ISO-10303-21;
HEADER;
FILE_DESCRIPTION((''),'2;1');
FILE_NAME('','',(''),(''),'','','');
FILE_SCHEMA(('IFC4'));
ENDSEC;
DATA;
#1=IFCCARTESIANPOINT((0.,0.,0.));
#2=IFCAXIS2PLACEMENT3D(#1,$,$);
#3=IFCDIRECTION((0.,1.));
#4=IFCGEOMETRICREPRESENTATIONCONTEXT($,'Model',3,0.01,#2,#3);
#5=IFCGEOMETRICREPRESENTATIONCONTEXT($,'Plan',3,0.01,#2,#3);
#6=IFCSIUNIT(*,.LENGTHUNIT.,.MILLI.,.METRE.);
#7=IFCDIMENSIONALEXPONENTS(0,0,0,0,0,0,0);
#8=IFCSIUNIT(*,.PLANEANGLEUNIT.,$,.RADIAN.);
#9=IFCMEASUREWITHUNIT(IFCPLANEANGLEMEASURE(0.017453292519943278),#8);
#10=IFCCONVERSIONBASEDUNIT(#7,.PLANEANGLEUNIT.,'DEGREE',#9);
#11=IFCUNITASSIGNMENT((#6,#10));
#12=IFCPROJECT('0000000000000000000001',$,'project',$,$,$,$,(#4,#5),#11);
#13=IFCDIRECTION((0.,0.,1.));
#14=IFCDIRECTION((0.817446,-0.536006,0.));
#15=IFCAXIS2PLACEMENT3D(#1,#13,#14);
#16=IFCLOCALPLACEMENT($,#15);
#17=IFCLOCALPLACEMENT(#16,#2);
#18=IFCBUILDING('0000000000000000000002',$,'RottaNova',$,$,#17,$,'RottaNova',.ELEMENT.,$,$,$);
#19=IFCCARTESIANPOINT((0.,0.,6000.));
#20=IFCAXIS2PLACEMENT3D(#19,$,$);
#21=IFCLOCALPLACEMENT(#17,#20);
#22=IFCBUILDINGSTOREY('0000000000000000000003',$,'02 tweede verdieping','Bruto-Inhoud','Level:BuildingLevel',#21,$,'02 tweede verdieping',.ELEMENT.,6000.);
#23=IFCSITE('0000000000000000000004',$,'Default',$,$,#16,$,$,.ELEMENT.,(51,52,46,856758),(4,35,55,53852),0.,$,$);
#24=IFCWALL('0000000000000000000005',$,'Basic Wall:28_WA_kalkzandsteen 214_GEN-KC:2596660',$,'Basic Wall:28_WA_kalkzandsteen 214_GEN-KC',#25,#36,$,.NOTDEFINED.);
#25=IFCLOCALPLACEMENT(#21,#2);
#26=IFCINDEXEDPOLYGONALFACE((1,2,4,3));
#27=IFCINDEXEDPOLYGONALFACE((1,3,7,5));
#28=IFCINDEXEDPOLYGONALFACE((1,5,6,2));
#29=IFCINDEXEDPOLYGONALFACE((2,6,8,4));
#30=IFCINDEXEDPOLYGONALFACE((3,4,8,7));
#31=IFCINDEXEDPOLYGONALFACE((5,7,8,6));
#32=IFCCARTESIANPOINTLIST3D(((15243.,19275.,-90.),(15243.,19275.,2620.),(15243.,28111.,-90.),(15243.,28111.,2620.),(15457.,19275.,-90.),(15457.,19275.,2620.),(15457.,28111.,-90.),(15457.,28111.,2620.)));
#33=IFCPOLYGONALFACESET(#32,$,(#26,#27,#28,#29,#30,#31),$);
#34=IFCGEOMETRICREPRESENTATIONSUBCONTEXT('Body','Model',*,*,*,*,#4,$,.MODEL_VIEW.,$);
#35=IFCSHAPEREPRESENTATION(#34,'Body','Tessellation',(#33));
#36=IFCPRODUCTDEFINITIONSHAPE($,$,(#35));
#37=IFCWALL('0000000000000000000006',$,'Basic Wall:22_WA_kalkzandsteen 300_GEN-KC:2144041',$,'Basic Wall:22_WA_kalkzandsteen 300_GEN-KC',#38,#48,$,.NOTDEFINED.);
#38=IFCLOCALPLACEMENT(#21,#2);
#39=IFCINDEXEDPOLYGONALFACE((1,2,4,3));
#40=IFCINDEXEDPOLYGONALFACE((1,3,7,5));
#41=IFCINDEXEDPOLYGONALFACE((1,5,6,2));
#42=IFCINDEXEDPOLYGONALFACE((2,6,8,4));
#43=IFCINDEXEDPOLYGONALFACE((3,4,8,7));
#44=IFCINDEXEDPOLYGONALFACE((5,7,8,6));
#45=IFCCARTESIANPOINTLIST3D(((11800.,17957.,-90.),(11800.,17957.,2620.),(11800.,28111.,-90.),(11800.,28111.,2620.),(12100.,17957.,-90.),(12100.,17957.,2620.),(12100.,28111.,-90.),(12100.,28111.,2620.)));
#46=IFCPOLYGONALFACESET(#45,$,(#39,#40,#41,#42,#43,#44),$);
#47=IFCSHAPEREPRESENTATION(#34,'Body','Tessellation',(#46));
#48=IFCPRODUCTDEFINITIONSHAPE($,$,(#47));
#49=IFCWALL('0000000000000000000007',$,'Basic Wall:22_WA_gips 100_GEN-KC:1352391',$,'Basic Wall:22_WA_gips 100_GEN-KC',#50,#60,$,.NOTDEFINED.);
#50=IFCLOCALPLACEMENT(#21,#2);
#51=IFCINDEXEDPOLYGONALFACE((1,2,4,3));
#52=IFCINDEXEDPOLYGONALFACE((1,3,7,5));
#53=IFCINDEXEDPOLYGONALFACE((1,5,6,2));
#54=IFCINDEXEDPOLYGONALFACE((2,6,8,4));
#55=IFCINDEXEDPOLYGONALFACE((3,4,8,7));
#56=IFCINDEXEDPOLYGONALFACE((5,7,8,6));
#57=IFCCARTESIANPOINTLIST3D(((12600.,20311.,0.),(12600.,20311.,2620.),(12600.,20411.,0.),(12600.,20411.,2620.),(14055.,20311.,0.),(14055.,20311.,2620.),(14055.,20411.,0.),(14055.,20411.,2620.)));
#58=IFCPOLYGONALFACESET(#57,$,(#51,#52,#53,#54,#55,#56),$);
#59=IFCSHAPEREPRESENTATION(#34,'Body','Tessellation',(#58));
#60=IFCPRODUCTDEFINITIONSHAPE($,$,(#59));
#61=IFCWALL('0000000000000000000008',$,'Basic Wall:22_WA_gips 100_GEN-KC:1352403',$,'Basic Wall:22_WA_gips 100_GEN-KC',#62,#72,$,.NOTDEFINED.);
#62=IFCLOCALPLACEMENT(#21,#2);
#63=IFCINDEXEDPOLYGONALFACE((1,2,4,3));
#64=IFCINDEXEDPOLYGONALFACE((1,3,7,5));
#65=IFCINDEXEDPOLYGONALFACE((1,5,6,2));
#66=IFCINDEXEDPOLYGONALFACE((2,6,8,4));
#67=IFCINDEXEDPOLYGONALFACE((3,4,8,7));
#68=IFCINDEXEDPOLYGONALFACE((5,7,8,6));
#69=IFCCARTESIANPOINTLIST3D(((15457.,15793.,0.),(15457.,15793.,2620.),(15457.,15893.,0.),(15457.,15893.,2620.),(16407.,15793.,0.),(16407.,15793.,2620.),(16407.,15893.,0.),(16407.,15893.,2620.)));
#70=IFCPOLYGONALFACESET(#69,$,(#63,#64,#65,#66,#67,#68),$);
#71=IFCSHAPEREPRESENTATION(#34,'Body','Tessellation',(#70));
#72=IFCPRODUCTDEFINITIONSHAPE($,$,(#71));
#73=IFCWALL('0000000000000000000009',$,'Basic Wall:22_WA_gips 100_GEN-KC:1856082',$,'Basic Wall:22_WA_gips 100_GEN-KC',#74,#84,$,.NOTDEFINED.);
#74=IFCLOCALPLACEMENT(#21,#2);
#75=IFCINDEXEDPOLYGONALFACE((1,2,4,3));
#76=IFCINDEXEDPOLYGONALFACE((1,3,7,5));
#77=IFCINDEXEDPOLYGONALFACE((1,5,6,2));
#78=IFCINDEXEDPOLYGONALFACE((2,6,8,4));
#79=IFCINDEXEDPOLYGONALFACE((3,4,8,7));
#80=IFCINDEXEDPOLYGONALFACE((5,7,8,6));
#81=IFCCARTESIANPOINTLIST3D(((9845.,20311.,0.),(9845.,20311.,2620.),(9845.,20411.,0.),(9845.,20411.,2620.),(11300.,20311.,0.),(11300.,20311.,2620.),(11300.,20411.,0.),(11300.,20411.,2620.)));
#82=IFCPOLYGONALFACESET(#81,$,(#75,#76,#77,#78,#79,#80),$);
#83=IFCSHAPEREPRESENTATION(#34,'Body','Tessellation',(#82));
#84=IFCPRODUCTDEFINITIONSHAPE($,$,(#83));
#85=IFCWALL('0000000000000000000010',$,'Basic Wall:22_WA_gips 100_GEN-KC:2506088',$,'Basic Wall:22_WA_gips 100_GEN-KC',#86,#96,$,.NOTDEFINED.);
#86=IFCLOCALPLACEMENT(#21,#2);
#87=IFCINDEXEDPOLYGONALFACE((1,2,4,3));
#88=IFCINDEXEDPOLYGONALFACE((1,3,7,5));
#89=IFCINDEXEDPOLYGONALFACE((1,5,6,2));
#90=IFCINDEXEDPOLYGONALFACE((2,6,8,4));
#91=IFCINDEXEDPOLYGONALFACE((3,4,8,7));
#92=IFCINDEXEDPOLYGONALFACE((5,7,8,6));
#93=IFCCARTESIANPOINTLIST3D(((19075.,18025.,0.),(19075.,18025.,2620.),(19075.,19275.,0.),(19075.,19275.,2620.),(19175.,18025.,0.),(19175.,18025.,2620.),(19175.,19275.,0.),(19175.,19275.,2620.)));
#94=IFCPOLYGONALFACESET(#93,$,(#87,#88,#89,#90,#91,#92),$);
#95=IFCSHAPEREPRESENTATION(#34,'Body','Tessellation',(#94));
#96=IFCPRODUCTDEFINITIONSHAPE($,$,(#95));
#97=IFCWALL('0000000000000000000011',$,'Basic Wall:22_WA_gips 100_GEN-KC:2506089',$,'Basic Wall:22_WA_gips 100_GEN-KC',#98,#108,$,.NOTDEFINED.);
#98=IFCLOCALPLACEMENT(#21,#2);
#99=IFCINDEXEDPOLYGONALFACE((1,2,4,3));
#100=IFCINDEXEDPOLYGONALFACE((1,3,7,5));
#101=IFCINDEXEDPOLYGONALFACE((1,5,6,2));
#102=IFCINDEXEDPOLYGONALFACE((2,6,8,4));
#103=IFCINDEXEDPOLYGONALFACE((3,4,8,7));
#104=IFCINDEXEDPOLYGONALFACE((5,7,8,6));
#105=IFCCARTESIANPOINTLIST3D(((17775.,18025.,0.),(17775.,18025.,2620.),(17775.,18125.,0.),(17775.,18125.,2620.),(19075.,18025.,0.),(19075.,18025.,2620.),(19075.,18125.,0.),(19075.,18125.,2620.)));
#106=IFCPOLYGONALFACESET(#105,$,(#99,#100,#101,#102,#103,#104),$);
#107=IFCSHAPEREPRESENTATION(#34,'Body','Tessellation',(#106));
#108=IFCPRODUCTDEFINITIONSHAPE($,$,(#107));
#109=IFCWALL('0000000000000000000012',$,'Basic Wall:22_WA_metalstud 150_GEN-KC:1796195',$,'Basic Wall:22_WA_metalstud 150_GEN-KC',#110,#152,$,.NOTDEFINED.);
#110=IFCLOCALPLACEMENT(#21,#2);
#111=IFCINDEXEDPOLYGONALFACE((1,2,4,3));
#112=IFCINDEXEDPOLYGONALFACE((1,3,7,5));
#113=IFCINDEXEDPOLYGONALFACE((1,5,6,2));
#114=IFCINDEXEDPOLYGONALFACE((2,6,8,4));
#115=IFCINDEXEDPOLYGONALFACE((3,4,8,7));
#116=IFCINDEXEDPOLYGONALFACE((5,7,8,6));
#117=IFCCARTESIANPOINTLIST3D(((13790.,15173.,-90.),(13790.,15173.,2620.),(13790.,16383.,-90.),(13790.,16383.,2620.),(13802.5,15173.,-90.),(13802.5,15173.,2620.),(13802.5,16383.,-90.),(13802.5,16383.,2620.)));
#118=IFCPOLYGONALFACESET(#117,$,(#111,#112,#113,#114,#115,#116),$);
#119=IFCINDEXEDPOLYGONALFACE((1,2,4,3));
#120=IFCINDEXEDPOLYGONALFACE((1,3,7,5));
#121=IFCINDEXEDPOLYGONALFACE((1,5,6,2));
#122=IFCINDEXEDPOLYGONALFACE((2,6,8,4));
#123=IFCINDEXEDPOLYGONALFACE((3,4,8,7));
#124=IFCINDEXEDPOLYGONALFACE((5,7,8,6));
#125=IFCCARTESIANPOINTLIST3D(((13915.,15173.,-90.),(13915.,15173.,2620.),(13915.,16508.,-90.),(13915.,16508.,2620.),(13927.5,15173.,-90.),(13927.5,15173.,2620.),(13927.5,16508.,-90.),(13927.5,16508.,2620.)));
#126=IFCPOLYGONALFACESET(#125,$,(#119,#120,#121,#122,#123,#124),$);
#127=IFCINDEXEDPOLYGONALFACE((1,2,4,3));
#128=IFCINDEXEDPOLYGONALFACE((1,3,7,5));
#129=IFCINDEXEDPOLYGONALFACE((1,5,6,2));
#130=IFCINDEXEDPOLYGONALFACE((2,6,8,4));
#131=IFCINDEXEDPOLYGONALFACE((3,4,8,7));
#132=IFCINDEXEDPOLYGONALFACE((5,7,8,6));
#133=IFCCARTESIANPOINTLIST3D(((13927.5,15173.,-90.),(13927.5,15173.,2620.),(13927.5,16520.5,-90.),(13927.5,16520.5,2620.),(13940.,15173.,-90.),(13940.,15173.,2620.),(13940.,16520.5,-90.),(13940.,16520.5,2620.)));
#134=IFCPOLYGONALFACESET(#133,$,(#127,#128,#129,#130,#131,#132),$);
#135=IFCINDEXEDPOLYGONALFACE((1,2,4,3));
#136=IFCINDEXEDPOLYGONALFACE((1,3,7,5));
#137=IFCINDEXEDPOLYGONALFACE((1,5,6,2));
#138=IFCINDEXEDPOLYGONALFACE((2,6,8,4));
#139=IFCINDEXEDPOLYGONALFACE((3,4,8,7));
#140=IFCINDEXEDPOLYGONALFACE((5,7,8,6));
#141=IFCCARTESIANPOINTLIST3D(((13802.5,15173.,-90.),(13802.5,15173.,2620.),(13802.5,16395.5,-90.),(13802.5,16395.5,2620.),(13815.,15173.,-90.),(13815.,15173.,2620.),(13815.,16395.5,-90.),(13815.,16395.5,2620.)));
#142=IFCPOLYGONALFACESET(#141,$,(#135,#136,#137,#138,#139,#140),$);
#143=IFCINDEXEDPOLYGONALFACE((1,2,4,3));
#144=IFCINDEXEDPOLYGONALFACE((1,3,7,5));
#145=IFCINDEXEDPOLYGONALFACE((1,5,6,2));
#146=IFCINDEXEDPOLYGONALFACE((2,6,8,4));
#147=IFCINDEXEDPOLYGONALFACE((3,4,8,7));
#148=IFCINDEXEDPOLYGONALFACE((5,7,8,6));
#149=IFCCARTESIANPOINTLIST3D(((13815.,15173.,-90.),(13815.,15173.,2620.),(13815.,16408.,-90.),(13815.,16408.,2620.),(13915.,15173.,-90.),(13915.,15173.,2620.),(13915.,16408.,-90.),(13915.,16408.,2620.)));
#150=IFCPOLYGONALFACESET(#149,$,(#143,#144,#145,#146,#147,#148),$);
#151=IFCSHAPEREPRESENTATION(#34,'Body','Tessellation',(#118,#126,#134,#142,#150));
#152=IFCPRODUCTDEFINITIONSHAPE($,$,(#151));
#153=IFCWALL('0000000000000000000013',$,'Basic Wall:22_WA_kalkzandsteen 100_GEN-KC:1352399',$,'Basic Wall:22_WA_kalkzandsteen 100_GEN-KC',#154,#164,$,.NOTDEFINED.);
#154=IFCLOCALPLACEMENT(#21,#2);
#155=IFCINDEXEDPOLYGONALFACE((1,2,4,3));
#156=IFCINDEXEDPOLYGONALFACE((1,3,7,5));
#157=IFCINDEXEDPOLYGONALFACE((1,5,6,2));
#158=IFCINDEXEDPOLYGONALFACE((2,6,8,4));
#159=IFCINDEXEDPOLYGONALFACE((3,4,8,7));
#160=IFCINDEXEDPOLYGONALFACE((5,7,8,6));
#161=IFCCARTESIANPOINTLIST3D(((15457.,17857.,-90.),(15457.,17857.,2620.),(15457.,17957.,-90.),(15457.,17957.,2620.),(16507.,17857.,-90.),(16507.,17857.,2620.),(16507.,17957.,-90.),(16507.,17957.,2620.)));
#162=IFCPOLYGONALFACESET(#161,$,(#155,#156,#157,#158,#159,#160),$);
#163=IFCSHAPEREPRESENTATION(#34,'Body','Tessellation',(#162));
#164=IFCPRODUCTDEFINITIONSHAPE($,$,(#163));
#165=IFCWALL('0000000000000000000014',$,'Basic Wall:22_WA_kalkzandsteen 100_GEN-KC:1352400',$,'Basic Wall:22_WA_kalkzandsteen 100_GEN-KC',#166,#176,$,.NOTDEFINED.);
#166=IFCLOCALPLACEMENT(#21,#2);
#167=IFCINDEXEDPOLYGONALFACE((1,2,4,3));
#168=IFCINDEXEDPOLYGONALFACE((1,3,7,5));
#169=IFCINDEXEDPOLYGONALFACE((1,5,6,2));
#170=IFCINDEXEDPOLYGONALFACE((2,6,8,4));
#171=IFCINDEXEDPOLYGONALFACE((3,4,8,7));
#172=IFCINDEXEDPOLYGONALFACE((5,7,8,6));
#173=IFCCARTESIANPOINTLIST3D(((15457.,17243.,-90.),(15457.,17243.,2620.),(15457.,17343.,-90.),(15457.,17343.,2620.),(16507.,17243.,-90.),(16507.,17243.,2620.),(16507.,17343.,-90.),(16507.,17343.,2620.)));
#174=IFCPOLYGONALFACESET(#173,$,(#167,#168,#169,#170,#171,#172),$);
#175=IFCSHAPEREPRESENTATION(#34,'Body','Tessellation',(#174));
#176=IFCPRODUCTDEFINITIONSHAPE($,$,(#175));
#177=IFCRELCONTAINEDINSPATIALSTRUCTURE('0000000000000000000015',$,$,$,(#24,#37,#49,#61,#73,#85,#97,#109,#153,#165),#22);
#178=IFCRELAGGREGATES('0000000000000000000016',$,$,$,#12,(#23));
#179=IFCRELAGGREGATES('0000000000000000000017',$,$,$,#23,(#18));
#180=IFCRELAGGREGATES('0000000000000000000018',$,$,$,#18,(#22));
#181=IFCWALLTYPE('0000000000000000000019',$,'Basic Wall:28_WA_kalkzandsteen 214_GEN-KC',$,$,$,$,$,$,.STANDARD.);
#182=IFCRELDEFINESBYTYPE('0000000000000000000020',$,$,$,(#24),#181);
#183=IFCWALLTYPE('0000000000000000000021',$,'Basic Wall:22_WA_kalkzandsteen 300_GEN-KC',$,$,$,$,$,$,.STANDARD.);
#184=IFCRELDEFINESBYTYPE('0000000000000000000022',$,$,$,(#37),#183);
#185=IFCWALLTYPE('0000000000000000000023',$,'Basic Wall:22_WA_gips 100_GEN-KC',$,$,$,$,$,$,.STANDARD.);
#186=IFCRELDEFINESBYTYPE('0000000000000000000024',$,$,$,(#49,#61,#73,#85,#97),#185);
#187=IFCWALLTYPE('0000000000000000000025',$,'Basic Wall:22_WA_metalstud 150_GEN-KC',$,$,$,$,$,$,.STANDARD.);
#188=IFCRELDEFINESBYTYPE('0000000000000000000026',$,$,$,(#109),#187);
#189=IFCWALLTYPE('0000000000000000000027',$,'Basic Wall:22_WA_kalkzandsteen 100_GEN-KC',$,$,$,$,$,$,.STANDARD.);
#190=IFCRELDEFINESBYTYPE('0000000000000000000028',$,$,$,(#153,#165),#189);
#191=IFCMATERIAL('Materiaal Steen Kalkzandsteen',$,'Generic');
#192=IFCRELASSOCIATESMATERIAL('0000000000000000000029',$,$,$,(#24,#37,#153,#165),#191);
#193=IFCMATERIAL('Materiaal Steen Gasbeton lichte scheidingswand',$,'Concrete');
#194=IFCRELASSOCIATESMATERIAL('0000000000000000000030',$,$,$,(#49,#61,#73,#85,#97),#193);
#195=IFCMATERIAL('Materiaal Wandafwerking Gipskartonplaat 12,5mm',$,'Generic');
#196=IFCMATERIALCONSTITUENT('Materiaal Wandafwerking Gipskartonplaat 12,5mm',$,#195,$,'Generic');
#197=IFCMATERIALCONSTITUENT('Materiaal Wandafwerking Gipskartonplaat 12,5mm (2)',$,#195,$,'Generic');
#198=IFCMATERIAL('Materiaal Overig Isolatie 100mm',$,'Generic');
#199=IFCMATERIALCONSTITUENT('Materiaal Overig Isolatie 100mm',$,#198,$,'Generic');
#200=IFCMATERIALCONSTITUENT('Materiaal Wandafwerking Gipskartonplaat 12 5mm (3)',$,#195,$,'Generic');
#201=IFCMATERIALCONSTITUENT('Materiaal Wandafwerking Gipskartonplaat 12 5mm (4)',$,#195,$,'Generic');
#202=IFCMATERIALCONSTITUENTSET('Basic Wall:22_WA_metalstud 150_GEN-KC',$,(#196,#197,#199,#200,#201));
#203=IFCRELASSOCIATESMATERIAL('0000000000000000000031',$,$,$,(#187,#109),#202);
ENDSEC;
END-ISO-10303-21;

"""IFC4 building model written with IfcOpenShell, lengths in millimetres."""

from ifc_helpers import new_model, entity, si_unit, converted_unit, direction, frame, origin, place, context, subcontext, project, spatial, indexed_curve, outline, extrude, material, constituent, constituent_set, type_object, element, save


model = new_model("IFC4")

# Units and contexts
model_context = context("Model", 3, precision=0.01, world=origin(), true_north=direction((0.0, 1.0)))
plan_context = context("Plan", 3, precision=0.01, world=origin(), true_north=direction((0.0, 1.0)))
body_context = subcontext(model_context, "Body", "Model", "MODEL_VIEW")
ifc_project = project(units=[si_unit("LENGTHUNIT", "METRE", prefix="MILLI"), converted_unit("PLANEANGLEUNIT", "DEGREE", entity("IfcPlaneAngleMeasure", 0.017453292519943278), si_unit("PLANEANGLEUNIT", "RADIAN"), dimensions=[0, 0, 0, 0, 0, 0, 0])], contexts=[model_context, plan_context])

# Site, building, storey
site_placement = place(None, frame((0.0, 0.0, 0.0), z_axis=(0.0, 0.0, 1.0), x_axis=(0.817446, -0.536006, 0.0)))
site = spatial("IfcSite", under=ifc_project, at=site_placement, Name="Default", CompositionType="ELEMENT", RefLatitude=(51, 52, 46, 856758), RefLongitude=(4, 35, 55, 53852), RefElevation=0.0)
building_placement = place(site_placement, origin())
building = spatial("IfcBuilding", under=site, at=building_placement, Name="RottaNova", LongName="RottaNova", CompositionType="ELEMENT")
storey_placement = place(building_placement, frame((0.0, 0.0, 6000.0)))
storey = spatial("IfcBuildingStorey", under=building, at=storey_placement, Name="02 tweede verdieping", Description="Bruto-Inhoud", ObjectType="Level:BuildingLevel", LongName="02 tweede verdieping", CompositionType="ELEMENT", Elevation=6000.0)

# Walls
ifc_material_1 = material(Name="Materiaal Steen Kalkzandsteen", Category="Generic")
wall_type_1 = type_object("IfcWallType", Name="Basic Wall:28_WA_kalkzandsteen 214_GEN-KC", PredefinedType="STANDARD")
wall_1_placement = place(storey_placement, frame((15350.0, 19275.0, -90.0), z_axis=(0.0, 0.0, 1.0), x_axis=(0.0, 1.0, 0.0)))
element("IfcWall", 1, at=wall_1_placement, inside=storey, type_object=wall_type_1, material=ifc_material_1, Name="Basic Wall:28_WA_kalkzandsteen 214_GEN-KC:2596660", ObjectType="Basic Wall:28_WA_kalkzandsteen 214_GEN-KC", PredefinedType="NOTDEFINED", context=body_context, shape_type="SweptSolid", body=[
    extrude(outline(indexed_curve([(-4418.0, -107.0), (4418.0, -107.0), (4418.0, 107.0), (-4418.0, 107.0), (-4418.0, -107.0)], self_intersect=False)), frame((4418.0, 0.0, 0.0), z_axis=(0.0, 0.0, 1.0), x_axis=(-1.0, 0.0, 0.0)), (0.0, 0.0, 1.0), 2710.0),
])
wall_type_2 = type_object("IfcWallType", Name="Basic Wall:22_WA_kalkzandsteen 300_GEN-KC", PredefinedType="STANDARD")
wall_2_placement = place(storey_placement, frame((11950.0, 17957.0, -90.0), z_axis=(0.0, 0.0, 1.0), x_axis=(0.0, 1.0, 0.0)))
element("IfcWall", 2, at=wall_2_placement, inside=storey, type_object=wall_type_2, material=ifc_material_1, Name="Basic Wall:22_WA_kalkzandsteen 300_GEN-KC:2144041", ObjectType="Basic Wall:22_WA_kalkzandsteen 300_GEN-KC", PredefinedType="NOTDEFINED", context=body_context, shape_type="SweptSolid", body=[
    extrude(outline(indexed_curve([(10154.0, 150.0), (0.0, 150.0), (0.0, -150.0), (10154.0, -150.0), (10154.0, 150.0)], self_intersect=False)), origin(), (0.0, 0.0, 1.0), 2710.0),
])
ifc_material_2 = material(Name="Materiaal Steen Gasbeton lichte scheidingswand", Category="Concrete")
wall_type_3 = type_object("IfcWallType", Name="Basic Wall:22_WA_gips 100_GEN-KC", PredefinedType="STANDARD")
wall_3_placement = place(storey_placement, frame((14055.0, 20361.0, 0.0), z_axis=(0.0, 0.0, 1.0), x_axis=(-1.0, 0.0, 0.0)))
element("IfcWall", 3, at=wall_3_placement, inside=storey, type_object=wall_type_3, material=ifc_material_2, Name="Basic Wall:22_WA_gips 100_GEN-KC:1352391", ObjectType="Basic Wall:22_WA_gips 100_GEN-KC", PredefinedType="NOTDEFINED", context=body_context, shape_type="SweptSolid", body=[
    extrude(outline(indexed_curve([(1455.0, 50.0), (0.0, 50.0), (0.0, -50.0), (1455.0, -50.0), (1455.0, 50.0)], self_intersect=False)), origin(), (0.0, 0.0, 1.0), 2620.0),
])
wall_4_placement = place(storey_placement, frame((16407.0, 15843.0, 0.0), z_axis=(0.0, 0.0, 1.0), x_axis=(-1.0, 0.0, 0.0)))
element("IfcWall", 4, at=wall_4_placement, inside=storey, type_object=wall_type_3, material=ifc_material_2, Name="Basic Wall:22_WA_gips 100_GEN-KC:1352403", ObjectType="Basic Wall:22_WA_gips 100_GEN-KC", PredefinedType="NOTDEFINED", context=body_context, shape_type="SweptSolid", body=[
    extrude(outline(indexed_curve([(950.0, 50.0), (0.0, 50.0), (0.0, -50.0), (950.0, -50.0), (950.0, 50.0)], self_intersect=False)), origin(), (0.0, 0.0, 1.0), 2620.0),
])
wall_5_placement = place(storey_placement, frame((9845.0, 20361.0, 0.0)))
element("IfcWall", 5, at=wall_5_placement, inside=storey, type_object=wall_type_3, material=ifc_material_2, Name="Basic Wall:22_WA_gips 100_GEN-KC:1856082", ObjectType="Basic Wall:22_WA_gips 100_GEN-KC", PredefinedType="NOTDEFINED", context=body_context, shape_type="SweptSolid", body=[
    extrude(outline(indexed_curve([(1455.0, 50.0), (0.0, 50.0), (0.0, -50.0), (1455.0, -50.0), (1455.0, 50.0)], self_intersect=False)), origin(), (0.0, 0.0, 1.0), 2620.0),
])
wall_6_placement = place(storey_placement, frame((19125.0, 19275.0, 0.0), z_axis=(0.0, 0.0, 1.0), x_axis=(0.0, -1.0, 0.0)))
element("IfcWall", 6, at=wall_6_placement, inside=storey, type_object=wall_type_3, material=ifc_material_2, Name="Basic Wall:22_WA_gips 100_GEN-KC:2506088", ObjectType="Basic Wall:22_WA_gips 100_GEN-KC", PredefinedType="NOTDEFINED", context=body_context, shape_type="SweptSolid", body=[
    extrude(outline(indexed_curve([(1250.0, 50.0), (0.0, 50.0), (0.0, -50.0), (1250.0, -50.0), (1250.0, 50.0)], self_intersect=False)), origin(), (0.0, 0.0, 1.0), 2620.0),
])
wall_7_placement = place(storey_placement, frame((19075.0, 18075.0, 0.0), z_axis=(0.0, 0.0, 1.0), x_axis=(-1.0, 0.0, 0.0)))
element("IfcWall", 7, at=wall_7_placement, inside=storey, type_object=wall_type_3, material=ifc_material_2, Name="Basic Wall:22_WA_gips 100_GEN-KC:2506089", ObjectType="Basic Wall:22_WA_gips 100_GEN-KC", PredefinedType="NOTDEFINED", context=body_context, shape_type="SweptSolid", body=[
    extrude(outline(indexed_curve([(1300.0, 50.0), (0.0, 50.0), (0.0, -50.0), (1300.0, -50.0), (1300.0, 50.0)], self_intersect=False)), origin(), (0.0, 0.0, 1.0), 2620.0),
])
ifc_material_3 = material(Name="Materiaal Wandafwerking Gipskartonplaat 12,5mm", Category="Generic")
ifc_constituent_1 = constituent(ifc_material_3, Name="Materiaal Wandafwerking Gipskartonplaat 12,5mm", Category="Generic")
ifc_constituent_2 = constituent(ifc_material_3, Name="Materiaal Wandafwerking Gipskartonplaat 12,5mm (2)", Category="Generic")
ifc_material_4 = material(Name="Materiaal Overig Isolatie 100mm", Category="Generic")
ifc_constituent_3 = constituent(ifc_material_4, Name="Materiaal Overig Isolatie 100mm", Category="Generic")
ifc_constituent_4 = constituent(ifc_material_3, Name="Materiaal Wandafwerking Gipskartonplaat 12 5mm (3)", Category="Generic")
ifc_constituent_5 = constituent(ifc_material_3, Name="Materiaal Wandafwerking Gipskartonplaat 12 5mm (4)", Category="Generic")
ifc_constituent_set_1 = constituent_set(constituents=[ifc_constituent_1, ifc_constituent_2, ifc_constituent_3, ifc_constituent_4, ifc_constituent_5], Name="Basic Wall:22_WA_metalstud 150_GEN-KC")
wall_type_4 = type_object("IfcWallType", Name="Basic Wall:22_WA_metalstud 150_GEN-KC", PredefinedType="STANDARD", material=ifc_constituent_set_1)
wall_8_placement = place(storey_placement, frame((13865.0, 15173.0, -90.0), z_axis=(0.0, 0.0, 1.0), x_axis=(0.0, 1.0, 0.0)))
element("IfcWall", 8, at=wall_8_placement, inside=storey, type_object=wall_type_4, material=ifc_constituent_set_1, Name="Basic Wall:22_WA_metalstud 150_GEN-KC:1796195", ObjectType="Basic Wall:22_WA_metalstud 150_GEN-KC", PredefinedType="NOTDEFINED", context=body_context, shape_type="SweptSolid", body=[
    extrude(outline(indexed_curve([(-6.3, -605.0), (6.2, -605.0), (6.3, 605.0), (-6.2, 605.0), (-6.3, -605.0)], self_intersect=False)), frame((605.0, 68.8, 0.0), z_axis=(0.0, 0.0, 1.0), x_axis=(0.0, -1.0, 0.0)), (0.0, 0.0, 1.0), 2710.0),
    extrude(outline(indexed_curve([(-667.5, -6.3), (667.5, -6.3), (667.5, 6.2), (-667.5, 6.3), (-667.5, -6.3)], self_intersect=False)), frame((667.5, -56.2, 0.0)), (0.0, 0.0, 1.0), 2710.0),
    extrude(outline(indexed_curve([(-6.2, -673.7), (6.3, -673.7), (6.3, 673.7), (-6.2, 673.7), (-6.2, -673.7)], self_intersect=False)), frame((673.7, -68.8, 0.0), z_axis=(0.0, 0.0, 1.0), x_axis=(0.0, 1.0, 0.0)), (0.0, 0.0, 1.0), 2710.0),
    extrude(outline(indexed_curve([(-611.2, -6.3), (611.2, -6.3), (611.2, 6.2), (-611.2, 6.3), (-611.2, -6.3)], self_intersect=False)), frame((611.2, 56.3, 0.0)), (0.0, 0.0, 1.0), 2710.0),
    extrude(outline(indexed_curve([(-617.5, -50.0), (617.5, -50.0), (617.5, 50.0), (-617.5, 50.0), (-617.5, -50.0)], self_intersect=False)), frame((617.5, 0.0, 0.0)), (0.0, 0.0, 1.0), 2710.0),
])
wall_type_5 = type_object("IfcWallType", Name="Basic Wall:22_WA_kalkzandsteen 100_GEN-KC", PredefinedType="STANDARD")
for number, where, z_axis, x_axis, name in (
    (9, (16507.0, 17907.0, -90.0), (0.0, 0.0, 1.0), (-1.0, 0.0, 0.0), "Basic Wall:22_WA_kalkzandsteen 100_GEN-KC:1352399"),
    (10, (16507.0, 17293.0, -90.0), (0.0, 0.0, 1.0), (-1.0, 0.0, 0.0), "Basic Wall:22_WA_kalkzandsteen 100_GEN-KC:1352400"),
):
    element("IfcWall", number, at=place(storey_placement, frame(where, z_axis=z_axis, x_axis=x_axis)), inside=storey, type_object=wall_type_5, material=ifc_material_1, Name=name, ObjectType="Basic Wall:22_WA_kalkzandsteen 100_GEN-KC", PredefinedType="NOTDEFINED", context=body_context, shape_type="SweptSolid", body=[
        extrude(outline(indexed_curve([(1050.0, 50.0), (0.0, 50.0), (0.0, -50.0), (1050.0, -50.0), (1050.0, 50.0)], self_intersect=False)), origin(), (0.0, 0.0, 1.0), 2710.0),
    ])

save(model, "model.ifc")
